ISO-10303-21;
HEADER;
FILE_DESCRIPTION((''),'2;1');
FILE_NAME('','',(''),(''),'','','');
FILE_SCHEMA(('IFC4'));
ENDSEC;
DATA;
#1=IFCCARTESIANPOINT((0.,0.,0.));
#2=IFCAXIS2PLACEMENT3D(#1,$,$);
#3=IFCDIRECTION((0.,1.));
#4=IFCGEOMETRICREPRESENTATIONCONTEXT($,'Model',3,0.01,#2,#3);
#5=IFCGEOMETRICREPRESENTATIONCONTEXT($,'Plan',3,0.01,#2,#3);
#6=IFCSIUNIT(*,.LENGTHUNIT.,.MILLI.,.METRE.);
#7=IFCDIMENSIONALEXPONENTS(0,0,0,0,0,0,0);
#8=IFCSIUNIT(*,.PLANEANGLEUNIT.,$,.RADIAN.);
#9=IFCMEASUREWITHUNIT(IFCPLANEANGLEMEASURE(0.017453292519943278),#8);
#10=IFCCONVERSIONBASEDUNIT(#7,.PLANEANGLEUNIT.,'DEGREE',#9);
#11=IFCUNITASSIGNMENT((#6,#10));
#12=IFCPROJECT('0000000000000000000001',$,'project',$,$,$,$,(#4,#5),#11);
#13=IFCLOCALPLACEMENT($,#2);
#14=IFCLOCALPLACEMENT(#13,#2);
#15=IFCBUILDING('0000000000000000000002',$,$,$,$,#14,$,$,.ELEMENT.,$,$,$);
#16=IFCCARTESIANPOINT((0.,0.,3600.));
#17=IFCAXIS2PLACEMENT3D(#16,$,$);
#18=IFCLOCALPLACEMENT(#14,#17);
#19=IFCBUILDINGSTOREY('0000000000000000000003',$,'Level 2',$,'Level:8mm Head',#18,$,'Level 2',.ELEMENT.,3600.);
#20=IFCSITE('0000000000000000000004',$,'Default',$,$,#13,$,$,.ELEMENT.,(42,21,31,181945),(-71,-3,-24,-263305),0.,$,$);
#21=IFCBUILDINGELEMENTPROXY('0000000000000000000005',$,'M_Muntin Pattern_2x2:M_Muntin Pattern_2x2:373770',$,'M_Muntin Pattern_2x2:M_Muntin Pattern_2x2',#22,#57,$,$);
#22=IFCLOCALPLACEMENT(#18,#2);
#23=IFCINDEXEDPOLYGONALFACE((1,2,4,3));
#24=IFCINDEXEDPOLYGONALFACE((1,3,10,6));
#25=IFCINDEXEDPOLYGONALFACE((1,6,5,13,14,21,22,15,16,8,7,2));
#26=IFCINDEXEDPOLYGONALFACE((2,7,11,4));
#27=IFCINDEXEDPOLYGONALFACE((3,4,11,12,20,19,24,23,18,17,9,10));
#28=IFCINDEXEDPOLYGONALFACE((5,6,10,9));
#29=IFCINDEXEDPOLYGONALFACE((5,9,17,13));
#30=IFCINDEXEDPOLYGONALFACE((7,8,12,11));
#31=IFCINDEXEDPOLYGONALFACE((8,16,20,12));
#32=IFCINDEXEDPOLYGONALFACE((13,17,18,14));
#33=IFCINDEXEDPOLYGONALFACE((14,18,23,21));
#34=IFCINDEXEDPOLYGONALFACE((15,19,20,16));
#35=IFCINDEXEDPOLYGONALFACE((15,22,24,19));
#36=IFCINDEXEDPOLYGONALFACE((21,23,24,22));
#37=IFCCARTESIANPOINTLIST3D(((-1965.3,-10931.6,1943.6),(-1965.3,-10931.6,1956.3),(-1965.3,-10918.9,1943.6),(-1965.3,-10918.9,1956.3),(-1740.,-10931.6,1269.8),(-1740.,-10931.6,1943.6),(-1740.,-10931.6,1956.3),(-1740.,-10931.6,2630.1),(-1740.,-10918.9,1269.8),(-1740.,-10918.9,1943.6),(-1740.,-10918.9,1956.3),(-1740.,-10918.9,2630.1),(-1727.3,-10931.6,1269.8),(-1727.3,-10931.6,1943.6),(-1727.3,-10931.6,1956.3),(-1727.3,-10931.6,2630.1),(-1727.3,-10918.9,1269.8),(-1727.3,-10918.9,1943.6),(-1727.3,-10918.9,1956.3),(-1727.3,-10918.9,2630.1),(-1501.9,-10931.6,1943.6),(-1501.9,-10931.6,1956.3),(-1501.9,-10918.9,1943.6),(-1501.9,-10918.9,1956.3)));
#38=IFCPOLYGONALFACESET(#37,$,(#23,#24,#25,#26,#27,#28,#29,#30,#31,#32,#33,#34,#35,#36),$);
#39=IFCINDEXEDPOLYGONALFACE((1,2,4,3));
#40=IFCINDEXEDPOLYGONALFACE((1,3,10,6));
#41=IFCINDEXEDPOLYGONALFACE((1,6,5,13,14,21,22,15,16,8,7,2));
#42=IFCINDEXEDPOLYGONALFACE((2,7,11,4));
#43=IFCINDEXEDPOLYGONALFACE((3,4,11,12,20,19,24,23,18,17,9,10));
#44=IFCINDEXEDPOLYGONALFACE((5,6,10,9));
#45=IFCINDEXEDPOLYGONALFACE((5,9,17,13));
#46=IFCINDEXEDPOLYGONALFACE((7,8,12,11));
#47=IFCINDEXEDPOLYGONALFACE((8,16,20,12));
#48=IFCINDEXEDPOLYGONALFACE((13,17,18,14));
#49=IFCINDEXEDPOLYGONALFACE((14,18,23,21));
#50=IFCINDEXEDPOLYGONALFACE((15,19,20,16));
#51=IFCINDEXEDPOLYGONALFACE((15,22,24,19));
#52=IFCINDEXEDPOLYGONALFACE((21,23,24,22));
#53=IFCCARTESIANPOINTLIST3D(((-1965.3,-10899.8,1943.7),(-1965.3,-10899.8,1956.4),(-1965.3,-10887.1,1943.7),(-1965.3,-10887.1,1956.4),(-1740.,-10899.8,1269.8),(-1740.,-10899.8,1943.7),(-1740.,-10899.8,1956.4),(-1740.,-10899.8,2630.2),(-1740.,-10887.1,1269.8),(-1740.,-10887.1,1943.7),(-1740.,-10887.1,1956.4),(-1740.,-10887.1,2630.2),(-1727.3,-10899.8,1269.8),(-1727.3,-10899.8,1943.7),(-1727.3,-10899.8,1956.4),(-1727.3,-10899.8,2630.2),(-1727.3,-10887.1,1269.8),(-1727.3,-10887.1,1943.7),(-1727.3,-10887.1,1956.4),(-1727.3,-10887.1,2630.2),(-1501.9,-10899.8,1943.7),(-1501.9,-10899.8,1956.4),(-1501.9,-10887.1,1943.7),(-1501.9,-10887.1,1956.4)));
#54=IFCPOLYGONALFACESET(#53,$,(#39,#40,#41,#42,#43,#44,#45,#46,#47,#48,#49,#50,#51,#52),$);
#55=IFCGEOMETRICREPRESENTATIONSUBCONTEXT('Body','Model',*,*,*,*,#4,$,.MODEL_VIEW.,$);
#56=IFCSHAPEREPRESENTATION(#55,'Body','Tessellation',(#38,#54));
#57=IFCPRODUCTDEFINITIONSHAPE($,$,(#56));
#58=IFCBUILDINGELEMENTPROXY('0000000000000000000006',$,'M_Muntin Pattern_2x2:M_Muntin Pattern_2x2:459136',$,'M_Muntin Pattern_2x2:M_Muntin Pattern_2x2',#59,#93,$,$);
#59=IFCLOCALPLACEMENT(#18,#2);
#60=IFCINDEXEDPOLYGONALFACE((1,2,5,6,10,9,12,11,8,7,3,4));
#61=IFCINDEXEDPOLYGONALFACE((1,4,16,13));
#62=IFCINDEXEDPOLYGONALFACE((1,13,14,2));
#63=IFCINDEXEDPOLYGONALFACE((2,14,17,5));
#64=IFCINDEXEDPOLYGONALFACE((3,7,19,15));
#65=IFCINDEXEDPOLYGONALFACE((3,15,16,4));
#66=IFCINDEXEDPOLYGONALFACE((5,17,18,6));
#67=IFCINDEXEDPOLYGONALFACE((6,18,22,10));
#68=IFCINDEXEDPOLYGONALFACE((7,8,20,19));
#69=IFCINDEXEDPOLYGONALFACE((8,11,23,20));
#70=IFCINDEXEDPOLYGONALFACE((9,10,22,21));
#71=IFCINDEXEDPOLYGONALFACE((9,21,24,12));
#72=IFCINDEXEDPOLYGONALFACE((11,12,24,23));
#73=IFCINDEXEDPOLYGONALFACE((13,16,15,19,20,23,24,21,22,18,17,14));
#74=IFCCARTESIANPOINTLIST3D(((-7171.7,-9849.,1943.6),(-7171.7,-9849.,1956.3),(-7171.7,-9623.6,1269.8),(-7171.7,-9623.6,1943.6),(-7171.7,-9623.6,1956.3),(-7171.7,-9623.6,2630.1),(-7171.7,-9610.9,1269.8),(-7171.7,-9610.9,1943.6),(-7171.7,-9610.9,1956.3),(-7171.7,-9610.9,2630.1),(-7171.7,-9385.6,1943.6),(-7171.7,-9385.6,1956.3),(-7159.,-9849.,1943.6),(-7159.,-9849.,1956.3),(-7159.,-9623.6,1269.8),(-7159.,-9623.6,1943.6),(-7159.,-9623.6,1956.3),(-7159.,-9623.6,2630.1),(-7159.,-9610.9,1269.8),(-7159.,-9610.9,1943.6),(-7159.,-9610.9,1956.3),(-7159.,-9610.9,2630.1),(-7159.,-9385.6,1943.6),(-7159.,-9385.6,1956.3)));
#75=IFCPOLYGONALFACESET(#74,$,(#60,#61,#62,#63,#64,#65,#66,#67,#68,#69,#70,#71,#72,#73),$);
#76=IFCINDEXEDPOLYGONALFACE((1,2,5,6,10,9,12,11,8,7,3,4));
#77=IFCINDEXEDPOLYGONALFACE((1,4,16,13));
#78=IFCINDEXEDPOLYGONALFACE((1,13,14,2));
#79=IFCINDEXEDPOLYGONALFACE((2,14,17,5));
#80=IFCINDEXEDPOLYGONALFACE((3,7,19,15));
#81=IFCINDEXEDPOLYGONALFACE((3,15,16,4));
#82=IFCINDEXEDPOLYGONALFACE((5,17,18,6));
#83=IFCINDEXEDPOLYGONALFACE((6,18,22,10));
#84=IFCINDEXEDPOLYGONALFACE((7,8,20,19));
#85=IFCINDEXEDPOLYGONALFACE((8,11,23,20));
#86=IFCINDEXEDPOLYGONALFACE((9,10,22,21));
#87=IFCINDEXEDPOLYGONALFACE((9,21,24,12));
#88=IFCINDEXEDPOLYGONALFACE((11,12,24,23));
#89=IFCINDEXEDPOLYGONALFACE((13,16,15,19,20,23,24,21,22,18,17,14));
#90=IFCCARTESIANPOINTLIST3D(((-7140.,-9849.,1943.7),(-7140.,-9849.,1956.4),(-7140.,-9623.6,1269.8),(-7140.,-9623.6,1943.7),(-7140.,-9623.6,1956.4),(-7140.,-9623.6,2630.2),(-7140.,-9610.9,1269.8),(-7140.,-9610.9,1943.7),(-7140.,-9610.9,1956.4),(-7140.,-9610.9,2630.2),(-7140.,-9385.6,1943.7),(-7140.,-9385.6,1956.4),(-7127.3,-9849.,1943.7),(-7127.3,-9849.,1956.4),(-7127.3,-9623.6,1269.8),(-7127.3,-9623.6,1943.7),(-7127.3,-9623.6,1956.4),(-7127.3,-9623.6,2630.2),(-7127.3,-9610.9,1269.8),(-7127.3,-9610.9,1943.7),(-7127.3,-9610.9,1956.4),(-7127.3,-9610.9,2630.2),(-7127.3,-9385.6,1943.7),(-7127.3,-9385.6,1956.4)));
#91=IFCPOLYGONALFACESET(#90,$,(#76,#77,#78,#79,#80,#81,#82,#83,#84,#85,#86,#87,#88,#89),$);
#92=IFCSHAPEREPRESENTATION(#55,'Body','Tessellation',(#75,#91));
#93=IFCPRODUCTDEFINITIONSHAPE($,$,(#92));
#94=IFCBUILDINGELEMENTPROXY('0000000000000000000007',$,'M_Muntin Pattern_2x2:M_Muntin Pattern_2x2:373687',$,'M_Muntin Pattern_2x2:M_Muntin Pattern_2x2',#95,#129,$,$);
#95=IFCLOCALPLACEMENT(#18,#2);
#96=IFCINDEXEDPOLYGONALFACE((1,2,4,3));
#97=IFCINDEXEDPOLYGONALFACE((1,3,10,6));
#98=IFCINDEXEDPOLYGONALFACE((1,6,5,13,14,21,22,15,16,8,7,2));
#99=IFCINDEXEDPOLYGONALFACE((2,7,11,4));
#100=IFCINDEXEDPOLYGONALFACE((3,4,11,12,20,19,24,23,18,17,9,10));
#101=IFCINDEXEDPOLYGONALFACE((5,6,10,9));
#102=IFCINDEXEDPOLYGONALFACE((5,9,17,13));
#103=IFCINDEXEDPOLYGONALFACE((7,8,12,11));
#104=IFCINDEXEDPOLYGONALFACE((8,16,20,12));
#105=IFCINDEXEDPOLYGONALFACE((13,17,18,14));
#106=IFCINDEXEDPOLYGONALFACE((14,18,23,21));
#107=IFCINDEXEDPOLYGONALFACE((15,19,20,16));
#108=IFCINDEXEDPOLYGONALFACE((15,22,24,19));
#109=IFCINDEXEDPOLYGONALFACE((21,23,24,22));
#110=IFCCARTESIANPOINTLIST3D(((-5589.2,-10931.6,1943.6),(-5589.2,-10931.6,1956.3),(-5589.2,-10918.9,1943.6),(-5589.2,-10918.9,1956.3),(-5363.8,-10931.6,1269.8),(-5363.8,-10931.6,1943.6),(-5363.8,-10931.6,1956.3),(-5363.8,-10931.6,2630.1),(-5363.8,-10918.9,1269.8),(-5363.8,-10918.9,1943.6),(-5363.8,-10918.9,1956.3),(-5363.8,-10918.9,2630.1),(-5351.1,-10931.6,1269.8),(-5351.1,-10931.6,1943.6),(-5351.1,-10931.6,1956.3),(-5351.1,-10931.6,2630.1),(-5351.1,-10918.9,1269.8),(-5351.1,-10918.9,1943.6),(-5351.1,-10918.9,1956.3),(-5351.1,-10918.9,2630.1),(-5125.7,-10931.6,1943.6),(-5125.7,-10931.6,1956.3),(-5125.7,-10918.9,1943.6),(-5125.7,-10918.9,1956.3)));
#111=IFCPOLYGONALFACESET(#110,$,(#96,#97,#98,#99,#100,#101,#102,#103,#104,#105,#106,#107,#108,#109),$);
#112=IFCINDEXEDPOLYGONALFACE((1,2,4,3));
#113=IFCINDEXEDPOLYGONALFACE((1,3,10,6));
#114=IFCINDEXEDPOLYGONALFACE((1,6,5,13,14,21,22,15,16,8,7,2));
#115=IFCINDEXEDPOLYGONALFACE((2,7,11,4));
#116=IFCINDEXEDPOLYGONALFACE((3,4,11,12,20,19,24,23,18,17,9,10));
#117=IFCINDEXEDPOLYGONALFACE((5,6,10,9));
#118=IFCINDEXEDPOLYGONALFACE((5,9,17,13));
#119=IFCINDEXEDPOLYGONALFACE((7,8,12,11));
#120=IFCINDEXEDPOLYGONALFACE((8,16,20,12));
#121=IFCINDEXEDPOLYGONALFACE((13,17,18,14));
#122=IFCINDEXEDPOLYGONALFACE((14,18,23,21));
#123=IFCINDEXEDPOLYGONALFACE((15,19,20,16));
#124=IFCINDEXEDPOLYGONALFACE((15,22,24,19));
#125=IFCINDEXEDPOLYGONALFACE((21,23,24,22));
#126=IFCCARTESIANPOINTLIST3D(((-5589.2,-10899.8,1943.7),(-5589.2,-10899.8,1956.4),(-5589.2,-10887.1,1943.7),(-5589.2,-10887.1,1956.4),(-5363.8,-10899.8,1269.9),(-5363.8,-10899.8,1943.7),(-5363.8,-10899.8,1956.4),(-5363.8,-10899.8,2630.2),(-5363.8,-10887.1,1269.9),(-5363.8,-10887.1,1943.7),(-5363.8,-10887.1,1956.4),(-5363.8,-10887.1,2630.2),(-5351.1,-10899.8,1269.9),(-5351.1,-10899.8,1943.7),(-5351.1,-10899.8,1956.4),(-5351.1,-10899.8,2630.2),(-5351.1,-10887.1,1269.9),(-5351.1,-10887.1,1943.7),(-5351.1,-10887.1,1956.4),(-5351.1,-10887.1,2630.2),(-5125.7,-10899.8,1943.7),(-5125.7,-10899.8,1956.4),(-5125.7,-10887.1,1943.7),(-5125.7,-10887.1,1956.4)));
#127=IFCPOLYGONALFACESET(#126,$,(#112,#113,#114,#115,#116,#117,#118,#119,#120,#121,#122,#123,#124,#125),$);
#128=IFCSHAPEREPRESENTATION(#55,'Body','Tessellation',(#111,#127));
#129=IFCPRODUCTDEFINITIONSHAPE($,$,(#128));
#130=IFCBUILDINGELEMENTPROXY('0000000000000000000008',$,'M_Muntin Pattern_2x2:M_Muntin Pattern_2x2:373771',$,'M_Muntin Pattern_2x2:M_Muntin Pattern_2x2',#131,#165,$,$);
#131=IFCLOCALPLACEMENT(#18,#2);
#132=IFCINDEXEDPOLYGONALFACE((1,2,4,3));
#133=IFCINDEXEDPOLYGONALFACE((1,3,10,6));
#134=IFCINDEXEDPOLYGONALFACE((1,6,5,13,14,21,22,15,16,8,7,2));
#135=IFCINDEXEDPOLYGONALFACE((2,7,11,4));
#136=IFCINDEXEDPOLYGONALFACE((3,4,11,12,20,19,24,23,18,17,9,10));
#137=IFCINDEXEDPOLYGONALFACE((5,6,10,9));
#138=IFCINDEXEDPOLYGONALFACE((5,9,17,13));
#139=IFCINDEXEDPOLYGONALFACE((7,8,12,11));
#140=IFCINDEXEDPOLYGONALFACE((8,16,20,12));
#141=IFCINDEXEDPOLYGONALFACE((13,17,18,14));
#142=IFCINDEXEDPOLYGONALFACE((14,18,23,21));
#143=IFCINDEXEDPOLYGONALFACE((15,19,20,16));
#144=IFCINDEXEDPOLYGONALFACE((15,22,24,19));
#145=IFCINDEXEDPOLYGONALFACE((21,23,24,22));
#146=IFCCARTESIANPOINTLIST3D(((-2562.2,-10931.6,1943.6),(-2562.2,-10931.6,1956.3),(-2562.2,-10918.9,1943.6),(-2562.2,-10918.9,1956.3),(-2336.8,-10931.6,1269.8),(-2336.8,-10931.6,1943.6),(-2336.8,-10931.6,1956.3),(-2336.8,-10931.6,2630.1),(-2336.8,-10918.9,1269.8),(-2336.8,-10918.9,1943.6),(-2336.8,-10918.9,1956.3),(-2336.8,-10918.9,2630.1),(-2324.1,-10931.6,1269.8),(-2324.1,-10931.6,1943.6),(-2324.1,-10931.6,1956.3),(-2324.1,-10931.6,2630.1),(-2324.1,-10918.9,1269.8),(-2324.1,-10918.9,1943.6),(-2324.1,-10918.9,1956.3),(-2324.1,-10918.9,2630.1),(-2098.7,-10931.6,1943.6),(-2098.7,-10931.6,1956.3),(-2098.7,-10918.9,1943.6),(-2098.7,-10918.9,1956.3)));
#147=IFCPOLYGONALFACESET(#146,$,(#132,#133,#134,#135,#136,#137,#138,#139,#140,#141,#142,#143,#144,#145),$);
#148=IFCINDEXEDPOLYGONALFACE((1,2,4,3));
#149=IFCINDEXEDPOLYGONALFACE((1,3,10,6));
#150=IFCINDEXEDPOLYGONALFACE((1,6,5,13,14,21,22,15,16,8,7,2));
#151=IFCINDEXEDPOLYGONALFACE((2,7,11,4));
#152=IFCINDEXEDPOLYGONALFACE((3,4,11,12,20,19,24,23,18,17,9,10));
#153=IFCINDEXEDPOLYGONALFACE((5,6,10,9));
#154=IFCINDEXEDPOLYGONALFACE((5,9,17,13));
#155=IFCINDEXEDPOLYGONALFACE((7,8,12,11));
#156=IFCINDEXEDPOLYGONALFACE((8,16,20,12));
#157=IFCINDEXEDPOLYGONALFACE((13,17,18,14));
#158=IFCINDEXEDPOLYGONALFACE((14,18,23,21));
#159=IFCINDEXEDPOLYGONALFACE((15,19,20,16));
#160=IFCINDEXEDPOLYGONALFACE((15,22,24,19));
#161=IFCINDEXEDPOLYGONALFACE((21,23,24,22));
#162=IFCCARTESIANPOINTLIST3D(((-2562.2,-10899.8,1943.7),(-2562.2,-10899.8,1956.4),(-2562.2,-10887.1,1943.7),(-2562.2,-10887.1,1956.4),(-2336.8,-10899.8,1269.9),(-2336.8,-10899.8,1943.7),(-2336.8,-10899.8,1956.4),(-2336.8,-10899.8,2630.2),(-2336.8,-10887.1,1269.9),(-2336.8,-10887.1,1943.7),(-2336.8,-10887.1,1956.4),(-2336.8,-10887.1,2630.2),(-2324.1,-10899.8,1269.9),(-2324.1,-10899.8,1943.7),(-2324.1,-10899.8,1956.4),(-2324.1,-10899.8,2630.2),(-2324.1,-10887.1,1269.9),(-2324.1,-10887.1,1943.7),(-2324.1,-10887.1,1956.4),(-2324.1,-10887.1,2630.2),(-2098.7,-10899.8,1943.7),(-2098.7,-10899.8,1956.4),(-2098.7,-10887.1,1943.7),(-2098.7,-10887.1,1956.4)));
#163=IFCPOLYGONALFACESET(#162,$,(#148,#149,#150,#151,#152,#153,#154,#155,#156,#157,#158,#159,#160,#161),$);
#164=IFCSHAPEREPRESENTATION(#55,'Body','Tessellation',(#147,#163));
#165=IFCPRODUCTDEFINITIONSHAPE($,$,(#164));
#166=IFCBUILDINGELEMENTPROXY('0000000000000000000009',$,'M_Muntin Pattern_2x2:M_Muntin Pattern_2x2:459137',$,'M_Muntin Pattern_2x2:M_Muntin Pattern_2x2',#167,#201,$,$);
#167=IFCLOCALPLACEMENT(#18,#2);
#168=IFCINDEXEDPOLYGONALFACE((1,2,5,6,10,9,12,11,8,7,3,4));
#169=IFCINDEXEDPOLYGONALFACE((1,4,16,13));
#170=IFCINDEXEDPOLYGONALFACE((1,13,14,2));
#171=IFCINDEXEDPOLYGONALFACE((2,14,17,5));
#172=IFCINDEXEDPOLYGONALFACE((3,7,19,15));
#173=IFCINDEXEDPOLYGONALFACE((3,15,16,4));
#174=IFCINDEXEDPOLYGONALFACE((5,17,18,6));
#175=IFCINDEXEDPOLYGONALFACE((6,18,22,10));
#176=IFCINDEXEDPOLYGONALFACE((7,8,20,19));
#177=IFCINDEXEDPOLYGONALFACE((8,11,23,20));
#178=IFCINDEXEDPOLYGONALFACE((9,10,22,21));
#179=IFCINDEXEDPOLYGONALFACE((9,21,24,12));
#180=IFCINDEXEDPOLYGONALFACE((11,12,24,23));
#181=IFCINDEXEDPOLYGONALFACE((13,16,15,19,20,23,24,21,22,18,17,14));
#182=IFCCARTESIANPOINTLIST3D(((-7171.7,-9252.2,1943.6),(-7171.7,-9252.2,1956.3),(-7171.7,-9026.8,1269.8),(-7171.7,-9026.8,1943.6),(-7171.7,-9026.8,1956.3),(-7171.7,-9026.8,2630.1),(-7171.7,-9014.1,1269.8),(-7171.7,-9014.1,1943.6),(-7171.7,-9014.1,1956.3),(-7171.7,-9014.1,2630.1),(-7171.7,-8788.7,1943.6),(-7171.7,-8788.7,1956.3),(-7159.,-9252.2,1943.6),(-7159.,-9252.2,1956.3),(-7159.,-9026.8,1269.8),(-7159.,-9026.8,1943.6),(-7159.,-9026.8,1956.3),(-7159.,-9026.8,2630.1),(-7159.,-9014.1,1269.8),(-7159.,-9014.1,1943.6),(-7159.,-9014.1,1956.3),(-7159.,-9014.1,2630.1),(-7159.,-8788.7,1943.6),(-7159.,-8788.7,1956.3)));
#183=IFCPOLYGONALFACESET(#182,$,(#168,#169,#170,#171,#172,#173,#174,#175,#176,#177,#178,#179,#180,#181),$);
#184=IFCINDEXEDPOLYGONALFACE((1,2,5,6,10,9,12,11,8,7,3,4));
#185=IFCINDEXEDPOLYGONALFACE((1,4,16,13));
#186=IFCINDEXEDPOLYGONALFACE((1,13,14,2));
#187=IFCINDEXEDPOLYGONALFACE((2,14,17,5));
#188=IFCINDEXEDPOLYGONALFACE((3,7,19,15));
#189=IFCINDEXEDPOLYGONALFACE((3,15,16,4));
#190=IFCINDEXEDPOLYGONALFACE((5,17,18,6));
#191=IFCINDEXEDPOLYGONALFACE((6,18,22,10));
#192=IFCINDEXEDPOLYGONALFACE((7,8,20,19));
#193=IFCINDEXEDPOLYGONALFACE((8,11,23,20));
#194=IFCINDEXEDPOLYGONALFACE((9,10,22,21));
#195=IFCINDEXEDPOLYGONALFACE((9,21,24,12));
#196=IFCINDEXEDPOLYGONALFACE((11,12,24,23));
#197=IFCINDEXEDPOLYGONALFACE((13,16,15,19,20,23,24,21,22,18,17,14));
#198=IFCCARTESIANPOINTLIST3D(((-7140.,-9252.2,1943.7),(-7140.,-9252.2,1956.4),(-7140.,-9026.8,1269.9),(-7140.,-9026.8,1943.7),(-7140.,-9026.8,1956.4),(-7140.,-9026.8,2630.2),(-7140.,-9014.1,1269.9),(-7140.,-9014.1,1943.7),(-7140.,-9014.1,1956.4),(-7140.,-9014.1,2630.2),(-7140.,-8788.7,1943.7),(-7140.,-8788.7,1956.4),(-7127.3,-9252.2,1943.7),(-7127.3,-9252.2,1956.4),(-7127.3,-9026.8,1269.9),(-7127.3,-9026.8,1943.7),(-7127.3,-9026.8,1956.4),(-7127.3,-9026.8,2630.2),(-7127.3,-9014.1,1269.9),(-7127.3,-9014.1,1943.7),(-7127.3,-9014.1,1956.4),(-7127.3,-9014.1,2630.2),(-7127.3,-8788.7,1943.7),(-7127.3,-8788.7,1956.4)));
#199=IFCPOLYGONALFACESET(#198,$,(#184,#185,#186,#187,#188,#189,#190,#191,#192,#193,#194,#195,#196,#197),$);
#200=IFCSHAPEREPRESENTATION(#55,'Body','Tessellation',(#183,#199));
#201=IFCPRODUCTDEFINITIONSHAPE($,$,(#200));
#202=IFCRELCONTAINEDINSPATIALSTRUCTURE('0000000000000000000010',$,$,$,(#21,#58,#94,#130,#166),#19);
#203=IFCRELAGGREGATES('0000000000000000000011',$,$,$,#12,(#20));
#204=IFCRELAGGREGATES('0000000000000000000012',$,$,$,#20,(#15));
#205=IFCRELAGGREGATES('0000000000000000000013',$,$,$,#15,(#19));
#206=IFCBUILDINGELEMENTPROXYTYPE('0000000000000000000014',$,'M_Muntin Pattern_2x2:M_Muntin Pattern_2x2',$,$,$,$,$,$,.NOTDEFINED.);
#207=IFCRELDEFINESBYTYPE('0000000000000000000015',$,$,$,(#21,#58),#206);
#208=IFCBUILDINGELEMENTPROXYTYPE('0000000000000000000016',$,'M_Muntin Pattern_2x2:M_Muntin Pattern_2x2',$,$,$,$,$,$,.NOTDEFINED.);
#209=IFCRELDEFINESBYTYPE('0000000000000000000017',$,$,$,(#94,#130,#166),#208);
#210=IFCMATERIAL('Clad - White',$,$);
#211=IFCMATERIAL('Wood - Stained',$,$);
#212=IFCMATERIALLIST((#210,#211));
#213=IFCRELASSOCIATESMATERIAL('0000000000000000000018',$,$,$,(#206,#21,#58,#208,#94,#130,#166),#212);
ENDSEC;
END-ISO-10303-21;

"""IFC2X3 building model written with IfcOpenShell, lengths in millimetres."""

from ifc_helpers import new_model, entity, si_unit, converted_unit, direction, frame, origin, place, context, subcontext, project, spatial, polyline, outline, extrude, source, transform, mapped, material, material_list, type_object, type_shapes, element, save


model = new_model("IFC2X3")

# Units and contexts
model_context = context("Model", 3, precision=0.01, world=origin(), true_north=direction((0.0, 1.0)))
plan_context = context("Plan", 3, precision=0.01, world=origin(), true_north=direction((0.0, 1.0)))
body_context = subcontext(model_context, "Body", "Model", "MODEL_VIEW")
ifc_project = project(units=[si_unit("LENGTHUNIT", "METRE", prefix="MILLI"), converted_unit("PLANEANGLEUNIT", "DEGREE", entity("IfcPlaneAngleMeasure", 0.017453292519943278), si_unit("PLANEANGLEUNIT", "RADIAN"), dimensions=[0, 0, 0, 0, 0, 0, 0])], contexts=[model_context, plan_context])

# Site, building, storey
site_placement = place(None, origin())
site = spatial("IfcSite", under=ifc_project, at=site_placement, Name="Default", CompositionType="ELEMENT", RefLatitude=(42, 21, 31, 181945), RefLongitude=(-71, -3, -24, -263305), RefElevation=0.0)
building_placement = place(site_placement, origin())
building = spatial("IfcBuilding", under=site, at=building_placement, CompositionType="ELEMENT")
storey_placement = place(building_placement, frame((0.0, 0.0, 3600.0)))
storey = spatial("IfcBuildingStorey", under=building, at=storey_placement, Name="Level 2", ObjectType="Level:8mm Head", LongName="Level 2", CompositionType="ELEMENT", Elevation=3600.0)

# Building element proxies
ifc_material_1 = material(Name="Clad - White")
ifc_material_2 = material(Name="Wood - Stained")
ifc_material_list_1 = material_list([ifc_material_1, ifc_material_2])
building_element_proxy_type_1 = type_object("IfcBuildingElementProxyType", Name="M_Muntin Pattern_2x2:M_Muntin Pattern_2x2", PredefinedType="NOTDEFINED", material=ifc_material_list_1)
shared_shape_1 = source(origin(), body_context, "Body", "SweptSolid", [
    extrude(outline(polyline([(6.4, -6.4), (680.1, -6.4), (680.1, 6.3), (6.4, 6.3), (6.4, 231.7), (-6.3, 231.7), (-6.3, 6.3), (-680.2, 6.3), (-680.2, -6.4), (-6.3, -6.4), (-6.3, -231.7), (6.4, -231.7), (6.4, -6.4)])), frame((0.0, 9.5, 680.1), z_axis=(0.0, 1.0, 0.0), x_axis=(0.0, 0.0, 1.0)), (0.0, 0.0, 1.0), 12.7),
    extrude(outline(polyline([(6.4, -6.4), (680.2, -6.4), (680.2, 6.3), (6.4, 6.3), (6.4, 231.7), (-6.3, 231.7), (-6.3, 6.3), (-680.2, 6.3), (-680.2, -6.4), (-6.3, -6.4), (-6.3, -231.7), (6.4, -231.7), (6.4, -6.4)])), frame((0.0, -22.2, 680.2), z_axis=(0.0, 1.0, 0.0), x_axis=(0.0, 0.0, 1.0)), (0.0, 0.0, 1.0), 12.7),
])
type_shapes(building_element_proxy_type_1, [shared_shape_1])
for number, where, z_axis, x_axis, name in (
    (1, (-1733.6, -10909.4, 1269.8), (0.0, 0.0, 1.0), (-1.0, 0.0, 0.0), "M_Muntin Pattern_2x2:M_Muntin Pattern_2x2:373770"),
    (2, (-7149.5, -9617.3, 1269.8), (0.0, 0.0, 1.0), (0.0, 1.0, 0.0), "M_Muntin Pattern_2x2:M_Muntin Pattern_2x2:459136"),
):
    element("IfcBuildingElementProxy", number, at=place(storey_placement, frame(where, z_axis=z_axis, x_axis=x_axis)), inside=storey, type_object=building_element_proxy_type_1, material=ifc_material_list_1, Name=name, ObjectType="M_Muntin Pattern_2x2:M_Muntin Pattern_2x2", context=body_context, shape_type="MappedRepresentation", body=[
        mapped(shared_shape_1, transform((0.0, 0.0, 0.0), scale=1.0)),
    ])
building_element_proxy_type_2 = type_object("IfcBuildingElementProxyType", Name="M_Muntin Pattern_2x2:M_Muntin Pattern_2x2", PredefinedType="NOTDEFINED", material=ifc_material_list_1)
shared_shape_2 = source(origin(), body_context, "Body", "SweptSolid", [
    extrude(outline(polyline([(6.4, -6.4), (680.1, -6.4), (680.1, 6.3), (6.4, 6.3), (6.4, 231.7), (-6.3, 231.7), (-6.3, 6.3), (-680.2, 6.3), (-680.2, -6.4), (-6.3, -6.4), (-6.3, -231.7), (6.4, -231.7), (6.4, -6.4)])), frame((0.0, -22.2, 680.1), z_axis=(0.0, 1.0, 0.0), x_axis=(0.0, 0.0, 1.0)), (0.0, 0.0, 1.0), 12.7),
    extrude(outline(polyline([(6.4, -6.4), (680.2, -6.4), (680.2, 6.3), (6.4, 6.3), (6.4, 231.7), (-6.3, 231.7), (-6.3, 6.3), (-680.2, 6.3), (-680.2, -6.4), (-6.3, -6.4), (-6.3, -231.7), (6.4, -231.7), (6.4, -6.4)])), frame((0.0, 9.5, 680.2), z_axis=(0.0, 1.0, 0.0), x_axis=(0.0, 0.0, 1.0)), (0.0, 0.0, 1.0), 12.7),
])
type_shapes(building_element_proxy_type_2, [shared_shape_2])
for number, where, name in (
    (3, (-5357.4, -10909.4, 1269.9), "M_Muntin Pattern_2x2:M_Muntin Pattern_2x2:373687"),
    (4, (-2330.4, -10909.4, 1269.9), "M_Muntin Pattern_2x2:M_Muntin Pattern_2x2:373771"),
):
    element("IfcBuildingElementProxy", number, at=place(storey_placement, frame(where)), inside=storey, type_object=building_element_proxy_type_2, material=ifc_material_list_1, Name=name, ObjectType="M_Muntin Pattern_2x2:M_Muntin Pattern_2x2", context=body_context, shape_type="MappedRepresentation", body=[
        mapped(shared_shape_2, transform((0.0, 0.0, 0.0), scale=1.0)),
    ])
proxy_placement = place(storey_placement, frame((-7149.5, -9020.5, 1269.9), z_axis=(0.0, 0.0, 1.0), x_axis=(0.0, -1.0, 0.0)))
element("IfcBuildingElementProxy", 5, at=proxy_placement, inside=storey, type_object=building_element_proxy_type_2, material=ifc_material_list_1, Name="M_Muntin Pattern_2x2:M_Muntin Pattern_2x2:459137", ObjectType="M_Muntin Pattern_2x2:M_Muntin Pattern_2x2", context=body_context, shape_type="MappedRepresentation", body=[
    mapped(shared_shape_2, transform((0.0, 0.0, 0.0), scale=1.0)),
])

save(model, "model.ifc")
